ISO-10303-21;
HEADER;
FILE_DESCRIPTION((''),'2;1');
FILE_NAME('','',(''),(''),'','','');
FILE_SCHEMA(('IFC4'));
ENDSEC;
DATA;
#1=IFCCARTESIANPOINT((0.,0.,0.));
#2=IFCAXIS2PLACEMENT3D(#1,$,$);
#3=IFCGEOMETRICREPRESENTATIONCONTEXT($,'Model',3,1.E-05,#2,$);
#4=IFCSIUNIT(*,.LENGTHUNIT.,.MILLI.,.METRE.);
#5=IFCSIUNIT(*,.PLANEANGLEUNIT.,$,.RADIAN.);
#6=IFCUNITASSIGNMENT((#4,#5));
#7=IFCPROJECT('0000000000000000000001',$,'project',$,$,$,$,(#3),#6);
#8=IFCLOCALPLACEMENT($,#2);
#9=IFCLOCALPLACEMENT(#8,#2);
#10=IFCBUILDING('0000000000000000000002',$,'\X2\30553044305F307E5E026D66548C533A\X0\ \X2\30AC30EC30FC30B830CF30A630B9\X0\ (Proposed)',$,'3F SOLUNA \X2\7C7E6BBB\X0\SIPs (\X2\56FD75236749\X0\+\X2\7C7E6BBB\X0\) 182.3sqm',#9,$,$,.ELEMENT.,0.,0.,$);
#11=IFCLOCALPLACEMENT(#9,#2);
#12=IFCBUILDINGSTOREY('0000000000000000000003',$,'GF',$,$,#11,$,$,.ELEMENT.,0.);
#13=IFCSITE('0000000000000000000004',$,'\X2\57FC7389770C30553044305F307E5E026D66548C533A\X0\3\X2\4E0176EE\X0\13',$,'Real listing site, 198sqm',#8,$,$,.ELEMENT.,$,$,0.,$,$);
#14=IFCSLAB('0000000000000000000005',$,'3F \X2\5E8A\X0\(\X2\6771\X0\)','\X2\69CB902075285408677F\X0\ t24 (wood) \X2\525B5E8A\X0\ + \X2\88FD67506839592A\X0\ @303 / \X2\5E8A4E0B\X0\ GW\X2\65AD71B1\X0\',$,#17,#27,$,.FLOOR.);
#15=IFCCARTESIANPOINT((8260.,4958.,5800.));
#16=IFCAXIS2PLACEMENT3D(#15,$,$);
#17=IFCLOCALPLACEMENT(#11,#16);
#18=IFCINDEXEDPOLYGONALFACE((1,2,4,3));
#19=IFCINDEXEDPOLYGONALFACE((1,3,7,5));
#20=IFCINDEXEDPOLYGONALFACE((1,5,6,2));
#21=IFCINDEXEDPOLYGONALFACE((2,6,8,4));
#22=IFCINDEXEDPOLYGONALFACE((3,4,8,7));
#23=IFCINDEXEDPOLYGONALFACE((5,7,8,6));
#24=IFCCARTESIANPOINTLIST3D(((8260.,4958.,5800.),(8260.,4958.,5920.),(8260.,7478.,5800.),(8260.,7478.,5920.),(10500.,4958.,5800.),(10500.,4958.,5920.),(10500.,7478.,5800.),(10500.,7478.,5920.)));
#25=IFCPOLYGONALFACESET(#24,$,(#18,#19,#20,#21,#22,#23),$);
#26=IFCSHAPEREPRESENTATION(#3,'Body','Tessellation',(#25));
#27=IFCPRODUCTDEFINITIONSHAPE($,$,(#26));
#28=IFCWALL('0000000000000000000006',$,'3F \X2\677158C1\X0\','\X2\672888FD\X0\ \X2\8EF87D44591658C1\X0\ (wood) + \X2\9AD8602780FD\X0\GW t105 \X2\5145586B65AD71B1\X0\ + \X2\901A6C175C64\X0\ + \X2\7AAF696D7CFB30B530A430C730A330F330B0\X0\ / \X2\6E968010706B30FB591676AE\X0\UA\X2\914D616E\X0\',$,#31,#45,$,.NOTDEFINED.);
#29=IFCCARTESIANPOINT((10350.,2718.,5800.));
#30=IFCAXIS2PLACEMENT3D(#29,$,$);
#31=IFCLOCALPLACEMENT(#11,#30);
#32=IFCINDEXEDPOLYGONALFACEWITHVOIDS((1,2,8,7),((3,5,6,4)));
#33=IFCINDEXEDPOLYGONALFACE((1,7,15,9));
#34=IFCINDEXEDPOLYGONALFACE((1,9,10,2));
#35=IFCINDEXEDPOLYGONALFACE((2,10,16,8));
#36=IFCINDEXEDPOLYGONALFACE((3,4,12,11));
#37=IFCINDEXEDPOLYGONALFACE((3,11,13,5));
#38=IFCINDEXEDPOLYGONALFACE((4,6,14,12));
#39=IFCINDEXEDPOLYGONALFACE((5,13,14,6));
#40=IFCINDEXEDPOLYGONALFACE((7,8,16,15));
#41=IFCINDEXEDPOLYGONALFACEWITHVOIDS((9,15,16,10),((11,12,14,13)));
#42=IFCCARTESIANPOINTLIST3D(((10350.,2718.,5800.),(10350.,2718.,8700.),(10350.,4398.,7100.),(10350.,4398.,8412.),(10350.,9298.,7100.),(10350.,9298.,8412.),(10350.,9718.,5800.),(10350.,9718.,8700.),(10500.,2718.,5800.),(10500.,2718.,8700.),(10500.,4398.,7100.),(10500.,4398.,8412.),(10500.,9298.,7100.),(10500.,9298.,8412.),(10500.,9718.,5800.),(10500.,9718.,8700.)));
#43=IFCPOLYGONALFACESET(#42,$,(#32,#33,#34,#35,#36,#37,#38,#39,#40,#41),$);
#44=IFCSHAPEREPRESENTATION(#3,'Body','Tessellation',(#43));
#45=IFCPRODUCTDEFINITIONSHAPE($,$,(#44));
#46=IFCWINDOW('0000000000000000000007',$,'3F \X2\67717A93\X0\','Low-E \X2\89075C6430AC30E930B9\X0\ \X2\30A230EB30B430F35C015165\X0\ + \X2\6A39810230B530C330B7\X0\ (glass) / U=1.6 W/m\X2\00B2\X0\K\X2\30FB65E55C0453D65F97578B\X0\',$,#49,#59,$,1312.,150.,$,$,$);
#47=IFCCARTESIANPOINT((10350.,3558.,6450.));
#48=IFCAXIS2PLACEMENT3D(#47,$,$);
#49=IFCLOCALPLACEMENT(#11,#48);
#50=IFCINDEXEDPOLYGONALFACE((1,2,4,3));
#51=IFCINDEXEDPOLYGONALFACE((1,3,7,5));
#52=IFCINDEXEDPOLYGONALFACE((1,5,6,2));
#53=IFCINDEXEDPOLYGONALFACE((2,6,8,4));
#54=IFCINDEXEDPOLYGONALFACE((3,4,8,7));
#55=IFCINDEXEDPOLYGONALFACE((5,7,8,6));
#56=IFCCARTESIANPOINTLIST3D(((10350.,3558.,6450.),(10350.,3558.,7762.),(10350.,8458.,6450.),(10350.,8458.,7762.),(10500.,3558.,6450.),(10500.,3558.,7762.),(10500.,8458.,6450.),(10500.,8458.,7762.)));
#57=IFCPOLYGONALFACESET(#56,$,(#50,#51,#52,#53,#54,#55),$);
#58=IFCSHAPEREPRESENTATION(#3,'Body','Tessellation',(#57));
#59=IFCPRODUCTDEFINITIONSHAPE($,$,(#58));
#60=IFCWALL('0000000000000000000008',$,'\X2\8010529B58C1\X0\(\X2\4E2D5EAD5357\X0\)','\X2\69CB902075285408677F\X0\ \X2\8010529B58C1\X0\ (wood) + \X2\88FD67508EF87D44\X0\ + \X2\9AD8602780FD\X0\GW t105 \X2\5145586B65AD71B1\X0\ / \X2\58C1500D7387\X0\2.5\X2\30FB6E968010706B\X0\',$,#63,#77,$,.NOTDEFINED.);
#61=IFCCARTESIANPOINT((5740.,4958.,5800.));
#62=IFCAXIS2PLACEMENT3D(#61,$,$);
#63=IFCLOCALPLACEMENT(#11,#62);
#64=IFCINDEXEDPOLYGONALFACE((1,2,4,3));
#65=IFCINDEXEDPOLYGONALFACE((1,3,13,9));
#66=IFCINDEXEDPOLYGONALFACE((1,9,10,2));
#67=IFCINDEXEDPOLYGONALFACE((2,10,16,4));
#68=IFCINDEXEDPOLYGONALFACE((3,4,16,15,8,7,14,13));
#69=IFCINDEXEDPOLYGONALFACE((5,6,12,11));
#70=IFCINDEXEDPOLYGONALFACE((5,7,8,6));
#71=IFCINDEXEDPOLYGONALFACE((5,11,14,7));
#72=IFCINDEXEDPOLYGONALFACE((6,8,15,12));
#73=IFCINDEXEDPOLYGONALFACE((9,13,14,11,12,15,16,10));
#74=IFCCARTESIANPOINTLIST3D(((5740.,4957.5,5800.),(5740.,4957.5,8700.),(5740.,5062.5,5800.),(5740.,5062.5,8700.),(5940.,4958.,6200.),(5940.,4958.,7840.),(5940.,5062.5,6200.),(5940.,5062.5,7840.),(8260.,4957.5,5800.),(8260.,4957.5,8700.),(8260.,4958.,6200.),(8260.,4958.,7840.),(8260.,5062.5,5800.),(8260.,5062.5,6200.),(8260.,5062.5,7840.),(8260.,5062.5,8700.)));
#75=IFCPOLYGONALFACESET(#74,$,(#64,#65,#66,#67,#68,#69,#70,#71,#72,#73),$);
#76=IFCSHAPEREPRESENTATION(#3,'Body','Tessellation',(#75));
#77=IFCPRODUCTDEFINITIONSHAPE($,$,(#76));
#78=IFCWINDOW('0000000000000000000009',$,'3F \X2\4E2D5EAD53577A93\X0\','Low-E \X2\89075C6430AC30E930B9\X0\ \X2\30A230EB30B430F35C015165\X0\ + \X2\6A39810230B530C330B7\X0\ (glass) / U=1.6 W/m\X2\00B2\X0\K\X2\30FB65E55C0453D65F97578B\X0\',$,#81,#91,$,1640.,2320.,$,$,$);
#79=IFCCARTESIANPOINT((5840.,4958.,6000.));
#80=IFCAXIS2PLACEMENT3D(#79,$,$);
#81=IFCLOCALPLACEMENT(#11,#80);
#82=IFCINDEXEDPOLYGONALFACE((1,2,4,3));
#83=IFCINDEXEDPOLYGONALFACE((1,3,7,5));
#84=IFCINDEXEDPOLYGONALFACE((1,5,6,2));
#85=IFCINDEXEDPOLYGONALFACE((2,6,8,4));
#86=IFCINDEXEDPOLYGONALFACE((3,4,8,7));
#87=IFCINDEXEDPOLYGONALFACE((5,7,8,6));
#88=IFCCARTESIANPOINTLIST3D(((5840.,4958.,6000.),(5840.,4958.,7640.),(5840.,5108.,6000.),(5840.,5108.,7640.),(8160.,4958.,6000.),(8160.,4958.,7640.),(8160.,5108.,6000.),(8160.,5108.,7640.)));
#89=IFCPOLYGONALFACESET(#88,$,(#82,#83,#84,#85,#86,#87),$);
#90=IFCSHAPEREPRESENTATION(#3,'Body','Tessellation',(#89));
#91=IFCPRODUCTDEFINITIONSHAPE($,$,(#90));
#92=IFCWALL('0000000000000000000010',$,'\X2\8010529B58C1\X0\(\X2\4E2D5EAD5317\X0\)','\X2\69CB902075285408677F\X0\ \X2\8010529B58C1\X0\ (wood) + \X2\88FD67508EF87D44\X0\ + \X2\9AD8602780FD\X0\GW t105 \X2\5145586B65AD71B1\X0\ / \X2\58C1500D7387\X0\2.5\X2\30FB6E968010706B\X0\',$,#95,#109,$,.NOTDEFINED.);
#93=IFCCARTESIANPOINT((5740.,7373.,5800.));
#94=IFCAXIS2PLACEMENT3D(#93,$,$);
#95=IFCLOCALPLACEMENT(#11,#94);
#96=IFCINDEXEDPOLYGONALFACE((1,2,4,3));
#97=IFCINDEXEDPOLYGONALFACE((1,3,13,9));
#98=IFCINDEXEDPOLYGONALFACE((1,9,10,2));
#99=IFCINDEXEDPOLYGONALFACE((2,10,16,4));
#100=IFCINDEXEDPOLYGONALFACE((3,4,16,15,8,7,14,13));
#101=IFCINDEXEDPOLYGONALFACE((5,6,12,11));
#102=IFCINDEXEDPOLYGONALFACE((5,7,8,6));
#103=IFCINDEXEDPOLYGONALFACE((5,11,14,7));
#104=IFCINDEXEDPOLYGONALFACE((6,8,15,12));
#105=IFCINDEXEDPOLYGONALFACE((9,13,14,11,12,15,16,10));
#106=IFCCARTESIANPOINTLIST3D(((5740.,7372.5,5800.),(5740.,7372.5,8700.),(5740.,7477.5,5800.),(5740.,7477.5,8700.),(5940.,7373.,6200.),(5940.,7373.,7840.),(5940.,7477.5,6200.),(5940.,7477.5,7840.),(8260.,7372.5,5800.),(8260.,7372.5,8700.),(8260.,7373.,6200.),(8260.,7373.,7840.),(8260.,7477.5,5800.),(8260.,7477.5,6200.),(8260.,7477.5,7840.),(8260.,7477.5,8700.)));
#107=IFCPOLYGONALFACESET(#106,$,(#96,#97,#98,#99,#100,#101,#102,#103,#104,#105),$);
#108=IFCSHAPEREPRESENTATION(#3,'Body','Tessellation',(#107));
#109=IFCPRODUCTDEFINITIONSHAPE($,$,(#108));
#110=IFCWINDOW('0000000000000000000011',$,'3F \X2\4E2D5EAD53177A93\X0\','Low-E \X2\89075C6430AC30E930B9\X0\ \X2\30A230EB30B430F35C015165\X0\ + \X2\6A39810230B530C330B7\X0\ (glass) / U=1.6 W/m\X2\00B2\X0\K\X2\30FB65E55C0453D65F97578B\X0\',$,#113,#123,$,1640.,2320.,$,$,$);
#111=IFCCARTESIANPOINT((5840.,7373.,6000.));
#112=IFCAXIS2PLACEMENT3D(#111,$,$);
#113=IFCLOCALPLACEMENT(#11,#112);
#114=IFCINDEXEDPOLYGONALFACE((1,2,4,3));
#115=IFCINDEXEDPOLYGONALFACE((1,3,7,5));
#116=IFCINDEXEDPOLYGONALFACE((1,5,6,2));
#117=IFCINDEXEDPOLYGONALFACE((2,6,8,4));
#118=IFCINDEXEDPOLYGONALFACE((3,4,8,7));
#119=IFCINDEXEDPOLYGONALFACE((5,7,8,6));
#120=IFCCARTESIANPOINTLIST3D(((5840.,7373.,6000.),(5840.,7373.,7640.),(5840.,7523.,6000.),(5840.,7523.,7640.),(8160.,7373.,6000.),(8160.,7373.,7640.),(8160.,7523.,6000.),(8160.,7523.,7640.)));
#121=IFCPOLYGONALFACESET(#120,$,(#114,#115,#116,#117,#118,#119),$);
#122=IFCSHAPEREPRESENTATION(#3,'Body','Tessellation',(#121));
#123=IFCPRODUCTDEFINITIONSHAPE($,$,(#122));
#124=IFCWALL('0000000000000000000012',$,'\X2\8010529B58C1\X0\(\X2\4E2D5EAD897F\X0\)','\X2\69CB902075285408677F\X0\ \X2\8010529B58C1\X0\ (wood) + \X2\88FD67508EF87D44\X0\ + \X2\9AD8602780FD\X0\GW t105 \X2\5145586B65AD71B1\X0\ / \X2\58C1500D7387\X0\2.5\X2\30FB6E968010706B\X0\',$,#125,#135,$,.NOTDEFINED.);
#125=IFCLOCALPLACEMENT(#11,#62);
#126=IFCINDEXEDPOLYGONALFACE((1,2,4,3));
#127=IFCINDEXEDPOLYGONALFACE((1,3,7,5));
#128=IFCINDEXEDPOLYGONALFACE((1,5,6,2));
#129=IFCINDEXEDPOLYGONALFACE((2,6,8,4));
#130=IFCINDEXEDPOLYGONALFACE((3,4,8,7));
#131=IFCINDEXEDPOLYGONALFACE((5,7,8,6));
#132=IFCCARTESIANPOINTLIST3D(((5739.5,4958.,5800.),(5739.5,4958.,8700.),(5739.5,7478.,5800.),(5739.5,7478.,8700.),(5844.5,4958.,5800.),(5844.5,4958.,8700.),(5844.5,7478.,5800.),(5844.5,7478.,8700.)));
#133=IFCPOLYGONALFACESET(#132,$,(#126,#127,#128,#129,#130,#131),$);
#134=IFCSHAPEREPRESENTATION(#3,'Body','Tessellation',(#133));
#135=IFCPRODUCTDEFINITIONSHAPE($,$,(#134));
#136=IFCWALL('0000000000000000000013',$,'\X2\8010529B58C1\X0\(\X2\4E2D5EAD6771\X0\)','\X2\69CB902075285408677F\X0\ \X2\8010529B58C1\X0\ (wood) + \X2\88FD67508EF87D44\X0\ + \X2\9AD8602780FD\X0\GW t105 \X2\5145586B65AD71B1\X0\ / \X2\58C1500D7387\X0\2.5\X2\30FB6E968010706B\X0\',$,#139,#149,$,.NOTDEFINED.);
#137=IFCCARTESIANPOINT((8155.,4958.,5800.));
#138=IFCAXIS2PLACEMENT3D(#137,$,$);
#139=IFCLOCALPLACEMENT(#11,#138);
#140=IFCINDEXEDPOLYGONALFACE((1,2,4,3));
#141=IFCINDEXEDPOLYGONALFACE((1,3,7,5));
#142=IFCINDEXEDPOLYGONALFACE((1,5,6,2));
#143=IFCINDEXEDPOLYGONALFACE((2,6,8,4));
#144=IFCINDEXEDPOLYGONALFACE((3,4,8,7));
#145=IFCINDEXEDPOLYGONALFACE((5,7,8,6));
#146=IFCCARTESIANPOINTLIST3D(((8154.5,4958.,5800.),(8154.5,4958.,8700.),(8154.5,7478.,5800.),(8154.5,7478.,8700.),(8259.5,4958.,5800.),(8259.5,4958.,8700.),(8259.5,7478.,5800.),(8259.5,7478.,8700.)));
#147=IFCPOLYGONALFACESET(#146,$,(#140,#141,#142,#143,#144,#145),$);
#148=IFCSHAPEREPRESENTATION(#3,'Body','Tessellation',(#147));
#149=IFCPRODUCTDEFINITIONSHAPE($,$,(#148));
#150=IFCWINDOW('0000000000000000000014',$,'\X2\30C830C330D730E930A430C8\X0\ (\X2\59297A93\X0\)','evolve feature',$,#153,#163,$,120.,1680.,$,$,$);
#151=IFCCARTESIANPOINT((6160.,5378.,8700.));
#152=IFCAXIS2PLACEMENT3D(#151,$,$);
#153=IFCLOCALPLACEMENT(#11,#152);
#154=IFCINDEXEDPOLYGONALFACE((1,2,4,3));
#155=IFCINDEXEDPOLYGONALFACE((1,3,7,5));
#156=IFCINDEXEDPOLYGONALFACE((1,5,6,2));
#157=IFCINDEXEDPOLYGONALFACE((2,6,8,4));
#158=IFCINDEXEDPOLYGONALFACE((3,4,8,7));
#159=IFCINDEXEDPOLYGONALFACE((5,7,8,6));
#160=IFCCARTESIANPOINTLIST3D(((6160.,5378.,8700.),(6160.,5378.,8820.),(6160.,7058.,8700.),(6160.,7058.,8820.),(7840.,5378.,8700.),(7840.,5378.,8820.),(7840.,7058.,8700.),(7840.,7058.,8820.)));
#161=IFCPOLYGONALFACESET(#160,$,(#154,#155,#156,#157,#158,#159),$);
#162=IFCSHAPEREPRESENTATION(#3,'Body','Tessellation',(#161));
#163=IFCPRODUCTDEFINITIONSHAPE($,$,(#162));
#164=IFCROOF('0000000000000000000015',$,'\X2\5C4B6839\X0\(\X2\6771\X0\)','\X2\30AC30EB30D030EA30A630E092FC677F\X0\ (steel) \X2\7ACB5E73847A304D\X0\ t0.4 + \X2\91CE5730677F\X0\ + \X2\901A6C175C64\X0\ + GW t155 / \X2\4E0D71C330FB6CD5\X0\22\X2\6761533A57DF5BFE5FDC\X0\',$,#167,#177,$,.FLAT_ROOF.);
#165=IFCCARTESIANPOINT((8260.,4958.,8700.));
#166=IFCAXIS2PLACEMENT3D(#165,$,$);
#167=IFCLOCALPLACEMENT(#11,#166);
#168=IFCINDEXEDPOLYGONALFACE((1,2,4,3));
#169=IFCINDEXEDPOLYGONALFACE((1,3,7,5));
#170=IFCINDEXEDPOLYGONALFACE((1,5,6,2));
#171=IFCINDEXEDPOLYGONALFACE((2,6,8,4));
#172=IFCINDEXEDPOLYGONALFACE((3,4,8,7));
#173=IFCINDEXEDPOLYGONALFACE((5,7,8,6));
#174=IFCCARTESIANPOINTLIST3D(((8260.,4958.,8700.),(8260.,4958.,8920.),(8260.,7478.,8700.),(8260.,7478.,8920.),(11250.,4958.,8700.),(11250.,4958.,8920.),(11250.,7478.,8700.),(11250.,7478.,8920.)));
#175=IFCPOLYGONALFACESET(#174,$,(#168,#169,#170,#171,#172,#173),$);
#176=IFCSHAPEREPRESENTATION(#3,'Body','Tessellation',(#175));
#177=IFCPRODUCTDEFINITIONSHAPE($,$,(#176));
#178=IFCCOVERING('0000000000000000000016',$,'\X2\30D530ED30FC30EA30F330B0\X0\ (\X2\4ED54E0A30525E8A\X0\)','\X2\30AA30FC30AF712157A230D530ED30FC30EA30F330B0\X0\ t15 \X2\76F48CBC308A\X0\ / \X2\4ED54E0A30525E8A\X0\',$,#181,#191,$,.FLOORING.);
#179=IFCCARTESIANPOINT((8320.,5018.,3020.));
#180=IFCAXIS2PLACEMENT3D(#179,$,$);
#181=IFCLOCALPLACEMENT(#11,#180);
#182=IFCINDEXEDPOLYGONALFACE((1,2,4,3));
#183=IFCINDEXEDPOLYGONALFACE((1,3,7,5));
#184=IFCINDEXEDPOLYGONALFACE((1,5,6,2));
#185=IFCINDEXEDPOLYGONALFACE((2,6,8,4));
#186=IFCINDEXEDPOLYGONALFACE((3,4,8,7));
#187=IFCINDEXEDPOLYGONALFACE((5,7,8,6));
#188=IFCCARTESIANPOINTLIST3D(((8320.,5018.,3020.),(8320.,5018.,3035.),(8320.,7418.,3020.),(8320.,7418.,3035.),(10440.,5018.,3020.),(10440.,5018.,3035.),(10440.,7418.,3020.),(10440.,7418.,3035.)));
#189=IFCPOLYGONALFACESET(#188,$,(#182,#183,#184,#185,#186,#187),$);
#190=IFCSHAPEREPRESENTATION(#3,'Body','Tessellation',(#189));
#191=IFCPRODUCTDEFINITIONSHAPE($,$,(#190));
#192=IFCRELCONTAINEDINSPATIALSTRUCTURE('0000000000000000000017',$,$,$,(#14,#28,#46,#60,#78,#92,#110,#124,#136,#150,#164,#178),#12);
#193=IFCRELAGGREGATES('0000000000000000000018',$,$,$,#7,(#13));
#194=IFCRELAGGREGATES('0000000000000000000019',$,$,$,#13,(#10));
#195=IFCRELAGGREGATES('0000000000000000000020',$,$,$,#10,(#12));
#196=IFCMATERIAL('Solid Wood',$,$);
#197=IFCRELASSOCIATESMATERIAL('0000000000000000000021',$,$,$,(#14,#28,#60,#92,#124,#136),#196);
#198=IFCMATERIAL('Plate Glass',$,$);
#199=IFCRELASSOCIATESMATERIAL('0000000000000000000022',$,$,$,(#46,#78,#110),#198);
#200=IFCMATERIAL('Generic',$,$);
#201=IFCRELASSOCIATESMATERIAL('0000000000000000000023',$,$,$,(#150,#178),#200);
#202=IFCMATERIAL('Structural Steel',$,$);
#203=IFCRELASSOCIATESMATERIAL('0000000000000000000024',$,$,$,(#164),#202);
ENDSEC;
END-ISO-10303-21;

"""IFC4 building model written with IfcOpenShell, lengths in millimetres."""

from ifc_helpers import new_model, si_unit, frame, frame_2d, origin, place, context, project, spatial, rectangle, extrude, material, element, fill, save


model = new_model("IFC4")

# Units and contexts
model_context = context("Model", 3, precision=1e-05, world=origin())
ifc_project = project(units=[si_unit("LENGTHUNIT", "METRE", prefix="MILLI"), si_unit("PLANEANGLEUNIT", "RADIAN")], contexts=[model_context])

# Site, building, storey
site_placement = place(None, origin())
site = spatial("IfcSite", under=ifc_project, at=site_placement, Name="埼玉県さいたま市浦和区3丁目13", ObjectType="Real listing site, 198sqm", CompositionType="ELEMENT", RefElevation=0.0)
building_placement = place(site_placement, origin())
building = spatial("IfcBuilding", under=site, at=building_placement, Name="さいたま市浦和区 ガレージハウス (Proposed)", ObjectType="3F SOLUNA 籾殻SIPs (国産杉+籾殻) 182.3sqm", CompositionType="ELEMENT", ElevationOfRefHeight=0.0, ElevationOfTerrain=0.0)
storey_placement = place(building_placement, origin())
storey = spatial("IfcBuildingStorey", under=building, at=storey_placement, Name="GF", CompositionType="ELEMENT", Elevation=0.0)

# Slab
ifc_material_1 = material(Name="Solid Wood")
slab_placement = place(storey_placement, frame((8260.0, 4958.0, 5800.0)))
element("IfcSlab", 1, at=slab_placement, inside=storey, material=ifc_material_1, Name="3F 床(東)", Description="構造用合板 t24 (wood) 剛床 + 製材根太 @303 / 床下 GW断熱", PredefinedType="FLOOR", context=model_context, shape_type="SweptSolid", body=[
    extrude(rectangle(XDim=2240.0, YDim=2520.0, at=frame_2d((1120.0, 1260.0))), frame((8260.0, 4958.0, 5800.0)), (0.0, 0.0, 1.0), 120.0),
])

# Walls, openings, windows
wall_1_placement = place(storey_placement, frame((10350.0, 2718.0, 5800.0)))
wall_1 = element("IfcWall", 2, at=wall_1_placement, inside=storey, material=ifc_material_1, Name="3F 東壁", Description="木製 軸組外壁 (wood) + 高性能GW t105 充填断熱 + 通気層 + 窯業系サイディング / 準耐火・外皮UA配慮", PredefinedType="NOTDEFINED", context=model_context, shape_type="SweptSolid", body=[
    extrude(rectangle(XDim=150.0, YDim=7000.0, at=frame_2d((75.0, 3500.0))), frame((10350.0, 2718.0, 5800.0)), (0.0, 0.0, 1.0), 2900.0),
])
opening_1_placement = place(storey_placement, frame((10350.0, 3558.0, 6450.0)))
opening_1 = element("IfcOpeningElement", 3, at=opening_1_placement, cuts=wall_1, PredefinedType="NOTDEFINED", context=model_context, shape_type="SweptSolid", body=[
    extrude(rectangle(XDim=150.0, YDim=4900.0, at=frame_2d((75.0, 2450.0))), frame((10350.0, 3558.0, 6450.0)), (0.0, 0.0, 1.0), 1312.0),
])
ifc_material_2 = material(Name="Plate Glass")
window_1_placement = place(storey_placement, frame((10350.0, 3558.0, 6450.0)))
window_1 = element("IfcWindow", 4, at=window_1_placement, inside=storey, material=ifc_material_2, Name="3F 東窓", Description="Low-E 複層ガラス アルゴン封入 + 樹脂サッシ (glass) / U=1.6 W/m²K・日射取得型", OverallHeight=1312.0, OverallWidth=150.0, context=model_context, shape_type="SweptSolid", body=[
    extrude(rectangle(XDim=150.0, YDim=4900.0, at=frame_2d((75.0, 2450.0))), frame((10350.0, 3558.0, 6450.0)), (0.0, 0.0, 1.0), 1312.0),
])
fill(opening_1, window_1)
wall_2_placement = place(storey_placement, frame((5740.0, 4958.0, 5800.0)))
wall_2 = element("IfcWall", 5, at=wall_2_placement, inside=storey, material=ifc_material_1, Name="耐力壁(中庭南)", Description="構造用合板 耐力壁 (wood) + 製材軸組 + 高性能GW t105 充填断熱 / 壁倍率2.5・準耐火", PredefinedType="NOTDEFINED", context=model_context, shape_type="SweptSolid", body=[
    extrude(rectangle(XDim=2520.0, YDim=105.0, at=frame_2d((1260.0, 52.0))), frame((5740.0, 4958.0, 5800.0)), (0.0, 0.0, 1.0), 2900.0),
])
opening_2_placement = place(storey_placement, frame((5840.0, 4958.0, 6000.0)))
opening_2 = element("IfcOpeningElement", 6, at=opening_2_placement, cuts=wall_2, PredefinedType="NOTDEFINED", context=model_context, shape_type="SweptSolid", body=[
    extrude(rectangle(XDim=2320.0, YDim=150.0, at=frame_2d((1160.0, 75.0))), frame((5840.0, 4958.0, 6000.0)), (0.0, 0.0, 1.0), 1640.0),
])
window_2_placement = place(storey_placement, frame((5840.0, 4958.0, 6000.0)))
window_2 = element("IfcWindow", 7, at=window_2_placement, inside=storey, material=ifc_material_2, Name="3F 中庭南窓", Description="Low-E 複層ガラス アルゴン封入 + 樹脂サッシ (glass) / U=1.6 W/m²K・日射取得型", OverallHeight=1640.0, OverallWidth=2320.0, context=model_context, shape_type="SweptSolid", body=[
    extrude(rectangle(XDim=2320.0, YDim=150.0, at=frame_2d((1160.0, 75.0))), frame((5840.0, 4958.0, 6000.0)), (0.0, 0.0, 1.0), 1640.0),
])
fill(opening_2, window_2)
wall_3_placement = place(storey_placement, frame((5740.0, 7373.0, 5800.0)))
wall_3 = element("IfcWall", 8, at=wall_3_placement, inside=storey, material=ifc_material_1, Name="耐力壁(中庭北)", Description="構造用合板 耐力壁 (wood) + 製材軸組 + 高性能GW t105 充填断熱 / 壁倍率2.5・準耐火", PredefinedType="NOTDEFINED", context=model_context, shape_type="SweptSolid", body=[
    extrude(rectangle(XDim=2520.0, YDim=105.0, at=frame_2d((1260.0, 52.0))), frame((5740.0, 7373.0, 5800.0)), (0.0, 0.0, 1.0), 2900.0),
])
opening_3_placement = place(storey_placement, frame((5840.0, 7373.0, 6000.0)))
opening_3 = element("IfcOpeningElement", 9, at=opening_3_placement, cuts=wall_3, PredefinedType="NOTDEFINED", context=model_context, shape_type="SweptSolid", body=[
    extrude(rectangle(XDim=2320.0, YDim=150.0, at=frame_2d((1160.0, 75.0))), frame((5840.0, 7373.0, 6000.0)), (0.0, 0.0, 1.0), 1640.0),
])
window_3_placement = place(storey_placement, frame((5840.0, 7373.0, 6000.0)))
window_3 = element("IfcWindow", 10, at=window_3_placement, inside=storey, material=ifc_material_2, Name="3F 中庭北窓", Description="Low-E 複層ガラス アルゴン封入 + 樹脂サッシ (glass) / U=1.6 W/m²K・日射取得型", OverallHeight=1640.0, OverallWidth=2320.0, context=model_context, shape_type="SweptSolid", body=[
    extrude(rectangle(XDim=2320.0, YDim=150.0, at=frame_2d((1160.0, 75.0))), frame((5840.0, 7373.0, 6000.0)), (0.0, 0.0, 1.0), 1640.0),
])
fill(opening_3, window_3)

# Walls
wall_4_placement = place(storey_placement, frame((5740.0, 4958.0, 5800.0)))
element("IfcWall", 11, at=wall_4_placement, inside=storey, material=ifc_material_1, Name="耐力壁(中庭西)", Description="構造用合板 耐力壁 (wood) + 製材軸組 + 高性能GW t105 充填断熱 / 壁倍率2.5・準耐火", PredefinedType="NOTDEFINED", context=model_context, shape_type="SweptSolid", body=[
    extrude(rectangle(XDim=105.0, YDim=2520.0, at=frame_2d((52.0, 1260.0))), frame((5740.0, 4958.0, 5800.0)), (0.0, 0.0, 1.0), 2900.0),
])
wall_5_placement = place(storey_placement, frame((8155.0, 4958.0, 5800.0)))
element("IfcWall", 12, at=wall_5_placement, inside=storey, material=ifc_material_1, Name="耐力壁(中庭東)", Description="構造用合板 耐力壁 (wood) + 製材軸組 + 高性能GW t105 充填断熱 / 壁倍率2.5・準耐火", PredefinedType="NOTDEFINED", context=model_context, shape_type="SweptSolid", body=[
    extrude(rectangle(XDim=105.0, YDim=2520.0, at=frame_2d((52.0, 1260.0))), frame((8155.0, 4958.0, 5800.0)), (0.0, 0.0, 1.0), 2900.0),
])

# Window
ifc_material_3 = material(Name="Generic")
window_4_placement = place(storey_placement, frame((6160.0, 5378.0, 8700.0)))
element("IfcWindow", 13, at=window_4_placement, inside=storey, material=ifc_material_3, Name="トップライト (天窓)", Description="evolve feature", OverallHeight=120.0, OverallWidth=1680.0, context=model_context, shape_type="SweptSolid", body=[
    extrude(rectangle(XDim=1680.0, YDim=1680.0, at=frame_2d((840.0, 840.0))), frame((6160.0, 5378.0, 8700.0)), (0.0, 0.0, 1.0), 120.0),
])

# Roof
ifc_material_4 = material(Name="Structural Steel")
for number, where, name in (
    (14, (8260.0, 4958.0, 8700.0), "屋根(東)"),
):
    element("IfcRoof", number, at=place(storey_placement, frame(where)), inside=storey, material=ifc_material_4, Name=name, Description="ガルバリウム鋼板 (steel) 立平葺き t0.4 + 野地板 + 通気層 + GW t155 / 不燃・法22条区域対応", PredefinedType="FLAT_ROOF", context=model_context, shape_type="SweptSolid", body=[
        extrude(rectangle(XDim=2990.0, YDim=2520.0, at=frame_2d((1495.0, 1260.0))), frame((8260.0, 4958.0, 8700.0)), (0.0, 0.0, 1.0), 220.0),
    ])

# Covering
covering_1_placement = place(storey_placement, frame((8320.0, 5018.0, 3020.0)))
element("IfcCovering", 15, at=covering_1_placement, inside=storey, material=ifc_material_3, Name="フローリング (仕上げ床)", Description="オーク無垢フローリング t15 直貼り / 仕上げ床", PredefinedType="FLOORING", context=model_context, shape_type="SweptSolid", body=[
    extrude(rectangle(XDim=2120.0, YDim=2400.0, at=frame_2d((1060.0, 1200.0))), frame((8320.0, 5018.0, 3020.0)), (0.0, 0.0, 1.0), 15.0),
])

save(model, "model.ifc")
